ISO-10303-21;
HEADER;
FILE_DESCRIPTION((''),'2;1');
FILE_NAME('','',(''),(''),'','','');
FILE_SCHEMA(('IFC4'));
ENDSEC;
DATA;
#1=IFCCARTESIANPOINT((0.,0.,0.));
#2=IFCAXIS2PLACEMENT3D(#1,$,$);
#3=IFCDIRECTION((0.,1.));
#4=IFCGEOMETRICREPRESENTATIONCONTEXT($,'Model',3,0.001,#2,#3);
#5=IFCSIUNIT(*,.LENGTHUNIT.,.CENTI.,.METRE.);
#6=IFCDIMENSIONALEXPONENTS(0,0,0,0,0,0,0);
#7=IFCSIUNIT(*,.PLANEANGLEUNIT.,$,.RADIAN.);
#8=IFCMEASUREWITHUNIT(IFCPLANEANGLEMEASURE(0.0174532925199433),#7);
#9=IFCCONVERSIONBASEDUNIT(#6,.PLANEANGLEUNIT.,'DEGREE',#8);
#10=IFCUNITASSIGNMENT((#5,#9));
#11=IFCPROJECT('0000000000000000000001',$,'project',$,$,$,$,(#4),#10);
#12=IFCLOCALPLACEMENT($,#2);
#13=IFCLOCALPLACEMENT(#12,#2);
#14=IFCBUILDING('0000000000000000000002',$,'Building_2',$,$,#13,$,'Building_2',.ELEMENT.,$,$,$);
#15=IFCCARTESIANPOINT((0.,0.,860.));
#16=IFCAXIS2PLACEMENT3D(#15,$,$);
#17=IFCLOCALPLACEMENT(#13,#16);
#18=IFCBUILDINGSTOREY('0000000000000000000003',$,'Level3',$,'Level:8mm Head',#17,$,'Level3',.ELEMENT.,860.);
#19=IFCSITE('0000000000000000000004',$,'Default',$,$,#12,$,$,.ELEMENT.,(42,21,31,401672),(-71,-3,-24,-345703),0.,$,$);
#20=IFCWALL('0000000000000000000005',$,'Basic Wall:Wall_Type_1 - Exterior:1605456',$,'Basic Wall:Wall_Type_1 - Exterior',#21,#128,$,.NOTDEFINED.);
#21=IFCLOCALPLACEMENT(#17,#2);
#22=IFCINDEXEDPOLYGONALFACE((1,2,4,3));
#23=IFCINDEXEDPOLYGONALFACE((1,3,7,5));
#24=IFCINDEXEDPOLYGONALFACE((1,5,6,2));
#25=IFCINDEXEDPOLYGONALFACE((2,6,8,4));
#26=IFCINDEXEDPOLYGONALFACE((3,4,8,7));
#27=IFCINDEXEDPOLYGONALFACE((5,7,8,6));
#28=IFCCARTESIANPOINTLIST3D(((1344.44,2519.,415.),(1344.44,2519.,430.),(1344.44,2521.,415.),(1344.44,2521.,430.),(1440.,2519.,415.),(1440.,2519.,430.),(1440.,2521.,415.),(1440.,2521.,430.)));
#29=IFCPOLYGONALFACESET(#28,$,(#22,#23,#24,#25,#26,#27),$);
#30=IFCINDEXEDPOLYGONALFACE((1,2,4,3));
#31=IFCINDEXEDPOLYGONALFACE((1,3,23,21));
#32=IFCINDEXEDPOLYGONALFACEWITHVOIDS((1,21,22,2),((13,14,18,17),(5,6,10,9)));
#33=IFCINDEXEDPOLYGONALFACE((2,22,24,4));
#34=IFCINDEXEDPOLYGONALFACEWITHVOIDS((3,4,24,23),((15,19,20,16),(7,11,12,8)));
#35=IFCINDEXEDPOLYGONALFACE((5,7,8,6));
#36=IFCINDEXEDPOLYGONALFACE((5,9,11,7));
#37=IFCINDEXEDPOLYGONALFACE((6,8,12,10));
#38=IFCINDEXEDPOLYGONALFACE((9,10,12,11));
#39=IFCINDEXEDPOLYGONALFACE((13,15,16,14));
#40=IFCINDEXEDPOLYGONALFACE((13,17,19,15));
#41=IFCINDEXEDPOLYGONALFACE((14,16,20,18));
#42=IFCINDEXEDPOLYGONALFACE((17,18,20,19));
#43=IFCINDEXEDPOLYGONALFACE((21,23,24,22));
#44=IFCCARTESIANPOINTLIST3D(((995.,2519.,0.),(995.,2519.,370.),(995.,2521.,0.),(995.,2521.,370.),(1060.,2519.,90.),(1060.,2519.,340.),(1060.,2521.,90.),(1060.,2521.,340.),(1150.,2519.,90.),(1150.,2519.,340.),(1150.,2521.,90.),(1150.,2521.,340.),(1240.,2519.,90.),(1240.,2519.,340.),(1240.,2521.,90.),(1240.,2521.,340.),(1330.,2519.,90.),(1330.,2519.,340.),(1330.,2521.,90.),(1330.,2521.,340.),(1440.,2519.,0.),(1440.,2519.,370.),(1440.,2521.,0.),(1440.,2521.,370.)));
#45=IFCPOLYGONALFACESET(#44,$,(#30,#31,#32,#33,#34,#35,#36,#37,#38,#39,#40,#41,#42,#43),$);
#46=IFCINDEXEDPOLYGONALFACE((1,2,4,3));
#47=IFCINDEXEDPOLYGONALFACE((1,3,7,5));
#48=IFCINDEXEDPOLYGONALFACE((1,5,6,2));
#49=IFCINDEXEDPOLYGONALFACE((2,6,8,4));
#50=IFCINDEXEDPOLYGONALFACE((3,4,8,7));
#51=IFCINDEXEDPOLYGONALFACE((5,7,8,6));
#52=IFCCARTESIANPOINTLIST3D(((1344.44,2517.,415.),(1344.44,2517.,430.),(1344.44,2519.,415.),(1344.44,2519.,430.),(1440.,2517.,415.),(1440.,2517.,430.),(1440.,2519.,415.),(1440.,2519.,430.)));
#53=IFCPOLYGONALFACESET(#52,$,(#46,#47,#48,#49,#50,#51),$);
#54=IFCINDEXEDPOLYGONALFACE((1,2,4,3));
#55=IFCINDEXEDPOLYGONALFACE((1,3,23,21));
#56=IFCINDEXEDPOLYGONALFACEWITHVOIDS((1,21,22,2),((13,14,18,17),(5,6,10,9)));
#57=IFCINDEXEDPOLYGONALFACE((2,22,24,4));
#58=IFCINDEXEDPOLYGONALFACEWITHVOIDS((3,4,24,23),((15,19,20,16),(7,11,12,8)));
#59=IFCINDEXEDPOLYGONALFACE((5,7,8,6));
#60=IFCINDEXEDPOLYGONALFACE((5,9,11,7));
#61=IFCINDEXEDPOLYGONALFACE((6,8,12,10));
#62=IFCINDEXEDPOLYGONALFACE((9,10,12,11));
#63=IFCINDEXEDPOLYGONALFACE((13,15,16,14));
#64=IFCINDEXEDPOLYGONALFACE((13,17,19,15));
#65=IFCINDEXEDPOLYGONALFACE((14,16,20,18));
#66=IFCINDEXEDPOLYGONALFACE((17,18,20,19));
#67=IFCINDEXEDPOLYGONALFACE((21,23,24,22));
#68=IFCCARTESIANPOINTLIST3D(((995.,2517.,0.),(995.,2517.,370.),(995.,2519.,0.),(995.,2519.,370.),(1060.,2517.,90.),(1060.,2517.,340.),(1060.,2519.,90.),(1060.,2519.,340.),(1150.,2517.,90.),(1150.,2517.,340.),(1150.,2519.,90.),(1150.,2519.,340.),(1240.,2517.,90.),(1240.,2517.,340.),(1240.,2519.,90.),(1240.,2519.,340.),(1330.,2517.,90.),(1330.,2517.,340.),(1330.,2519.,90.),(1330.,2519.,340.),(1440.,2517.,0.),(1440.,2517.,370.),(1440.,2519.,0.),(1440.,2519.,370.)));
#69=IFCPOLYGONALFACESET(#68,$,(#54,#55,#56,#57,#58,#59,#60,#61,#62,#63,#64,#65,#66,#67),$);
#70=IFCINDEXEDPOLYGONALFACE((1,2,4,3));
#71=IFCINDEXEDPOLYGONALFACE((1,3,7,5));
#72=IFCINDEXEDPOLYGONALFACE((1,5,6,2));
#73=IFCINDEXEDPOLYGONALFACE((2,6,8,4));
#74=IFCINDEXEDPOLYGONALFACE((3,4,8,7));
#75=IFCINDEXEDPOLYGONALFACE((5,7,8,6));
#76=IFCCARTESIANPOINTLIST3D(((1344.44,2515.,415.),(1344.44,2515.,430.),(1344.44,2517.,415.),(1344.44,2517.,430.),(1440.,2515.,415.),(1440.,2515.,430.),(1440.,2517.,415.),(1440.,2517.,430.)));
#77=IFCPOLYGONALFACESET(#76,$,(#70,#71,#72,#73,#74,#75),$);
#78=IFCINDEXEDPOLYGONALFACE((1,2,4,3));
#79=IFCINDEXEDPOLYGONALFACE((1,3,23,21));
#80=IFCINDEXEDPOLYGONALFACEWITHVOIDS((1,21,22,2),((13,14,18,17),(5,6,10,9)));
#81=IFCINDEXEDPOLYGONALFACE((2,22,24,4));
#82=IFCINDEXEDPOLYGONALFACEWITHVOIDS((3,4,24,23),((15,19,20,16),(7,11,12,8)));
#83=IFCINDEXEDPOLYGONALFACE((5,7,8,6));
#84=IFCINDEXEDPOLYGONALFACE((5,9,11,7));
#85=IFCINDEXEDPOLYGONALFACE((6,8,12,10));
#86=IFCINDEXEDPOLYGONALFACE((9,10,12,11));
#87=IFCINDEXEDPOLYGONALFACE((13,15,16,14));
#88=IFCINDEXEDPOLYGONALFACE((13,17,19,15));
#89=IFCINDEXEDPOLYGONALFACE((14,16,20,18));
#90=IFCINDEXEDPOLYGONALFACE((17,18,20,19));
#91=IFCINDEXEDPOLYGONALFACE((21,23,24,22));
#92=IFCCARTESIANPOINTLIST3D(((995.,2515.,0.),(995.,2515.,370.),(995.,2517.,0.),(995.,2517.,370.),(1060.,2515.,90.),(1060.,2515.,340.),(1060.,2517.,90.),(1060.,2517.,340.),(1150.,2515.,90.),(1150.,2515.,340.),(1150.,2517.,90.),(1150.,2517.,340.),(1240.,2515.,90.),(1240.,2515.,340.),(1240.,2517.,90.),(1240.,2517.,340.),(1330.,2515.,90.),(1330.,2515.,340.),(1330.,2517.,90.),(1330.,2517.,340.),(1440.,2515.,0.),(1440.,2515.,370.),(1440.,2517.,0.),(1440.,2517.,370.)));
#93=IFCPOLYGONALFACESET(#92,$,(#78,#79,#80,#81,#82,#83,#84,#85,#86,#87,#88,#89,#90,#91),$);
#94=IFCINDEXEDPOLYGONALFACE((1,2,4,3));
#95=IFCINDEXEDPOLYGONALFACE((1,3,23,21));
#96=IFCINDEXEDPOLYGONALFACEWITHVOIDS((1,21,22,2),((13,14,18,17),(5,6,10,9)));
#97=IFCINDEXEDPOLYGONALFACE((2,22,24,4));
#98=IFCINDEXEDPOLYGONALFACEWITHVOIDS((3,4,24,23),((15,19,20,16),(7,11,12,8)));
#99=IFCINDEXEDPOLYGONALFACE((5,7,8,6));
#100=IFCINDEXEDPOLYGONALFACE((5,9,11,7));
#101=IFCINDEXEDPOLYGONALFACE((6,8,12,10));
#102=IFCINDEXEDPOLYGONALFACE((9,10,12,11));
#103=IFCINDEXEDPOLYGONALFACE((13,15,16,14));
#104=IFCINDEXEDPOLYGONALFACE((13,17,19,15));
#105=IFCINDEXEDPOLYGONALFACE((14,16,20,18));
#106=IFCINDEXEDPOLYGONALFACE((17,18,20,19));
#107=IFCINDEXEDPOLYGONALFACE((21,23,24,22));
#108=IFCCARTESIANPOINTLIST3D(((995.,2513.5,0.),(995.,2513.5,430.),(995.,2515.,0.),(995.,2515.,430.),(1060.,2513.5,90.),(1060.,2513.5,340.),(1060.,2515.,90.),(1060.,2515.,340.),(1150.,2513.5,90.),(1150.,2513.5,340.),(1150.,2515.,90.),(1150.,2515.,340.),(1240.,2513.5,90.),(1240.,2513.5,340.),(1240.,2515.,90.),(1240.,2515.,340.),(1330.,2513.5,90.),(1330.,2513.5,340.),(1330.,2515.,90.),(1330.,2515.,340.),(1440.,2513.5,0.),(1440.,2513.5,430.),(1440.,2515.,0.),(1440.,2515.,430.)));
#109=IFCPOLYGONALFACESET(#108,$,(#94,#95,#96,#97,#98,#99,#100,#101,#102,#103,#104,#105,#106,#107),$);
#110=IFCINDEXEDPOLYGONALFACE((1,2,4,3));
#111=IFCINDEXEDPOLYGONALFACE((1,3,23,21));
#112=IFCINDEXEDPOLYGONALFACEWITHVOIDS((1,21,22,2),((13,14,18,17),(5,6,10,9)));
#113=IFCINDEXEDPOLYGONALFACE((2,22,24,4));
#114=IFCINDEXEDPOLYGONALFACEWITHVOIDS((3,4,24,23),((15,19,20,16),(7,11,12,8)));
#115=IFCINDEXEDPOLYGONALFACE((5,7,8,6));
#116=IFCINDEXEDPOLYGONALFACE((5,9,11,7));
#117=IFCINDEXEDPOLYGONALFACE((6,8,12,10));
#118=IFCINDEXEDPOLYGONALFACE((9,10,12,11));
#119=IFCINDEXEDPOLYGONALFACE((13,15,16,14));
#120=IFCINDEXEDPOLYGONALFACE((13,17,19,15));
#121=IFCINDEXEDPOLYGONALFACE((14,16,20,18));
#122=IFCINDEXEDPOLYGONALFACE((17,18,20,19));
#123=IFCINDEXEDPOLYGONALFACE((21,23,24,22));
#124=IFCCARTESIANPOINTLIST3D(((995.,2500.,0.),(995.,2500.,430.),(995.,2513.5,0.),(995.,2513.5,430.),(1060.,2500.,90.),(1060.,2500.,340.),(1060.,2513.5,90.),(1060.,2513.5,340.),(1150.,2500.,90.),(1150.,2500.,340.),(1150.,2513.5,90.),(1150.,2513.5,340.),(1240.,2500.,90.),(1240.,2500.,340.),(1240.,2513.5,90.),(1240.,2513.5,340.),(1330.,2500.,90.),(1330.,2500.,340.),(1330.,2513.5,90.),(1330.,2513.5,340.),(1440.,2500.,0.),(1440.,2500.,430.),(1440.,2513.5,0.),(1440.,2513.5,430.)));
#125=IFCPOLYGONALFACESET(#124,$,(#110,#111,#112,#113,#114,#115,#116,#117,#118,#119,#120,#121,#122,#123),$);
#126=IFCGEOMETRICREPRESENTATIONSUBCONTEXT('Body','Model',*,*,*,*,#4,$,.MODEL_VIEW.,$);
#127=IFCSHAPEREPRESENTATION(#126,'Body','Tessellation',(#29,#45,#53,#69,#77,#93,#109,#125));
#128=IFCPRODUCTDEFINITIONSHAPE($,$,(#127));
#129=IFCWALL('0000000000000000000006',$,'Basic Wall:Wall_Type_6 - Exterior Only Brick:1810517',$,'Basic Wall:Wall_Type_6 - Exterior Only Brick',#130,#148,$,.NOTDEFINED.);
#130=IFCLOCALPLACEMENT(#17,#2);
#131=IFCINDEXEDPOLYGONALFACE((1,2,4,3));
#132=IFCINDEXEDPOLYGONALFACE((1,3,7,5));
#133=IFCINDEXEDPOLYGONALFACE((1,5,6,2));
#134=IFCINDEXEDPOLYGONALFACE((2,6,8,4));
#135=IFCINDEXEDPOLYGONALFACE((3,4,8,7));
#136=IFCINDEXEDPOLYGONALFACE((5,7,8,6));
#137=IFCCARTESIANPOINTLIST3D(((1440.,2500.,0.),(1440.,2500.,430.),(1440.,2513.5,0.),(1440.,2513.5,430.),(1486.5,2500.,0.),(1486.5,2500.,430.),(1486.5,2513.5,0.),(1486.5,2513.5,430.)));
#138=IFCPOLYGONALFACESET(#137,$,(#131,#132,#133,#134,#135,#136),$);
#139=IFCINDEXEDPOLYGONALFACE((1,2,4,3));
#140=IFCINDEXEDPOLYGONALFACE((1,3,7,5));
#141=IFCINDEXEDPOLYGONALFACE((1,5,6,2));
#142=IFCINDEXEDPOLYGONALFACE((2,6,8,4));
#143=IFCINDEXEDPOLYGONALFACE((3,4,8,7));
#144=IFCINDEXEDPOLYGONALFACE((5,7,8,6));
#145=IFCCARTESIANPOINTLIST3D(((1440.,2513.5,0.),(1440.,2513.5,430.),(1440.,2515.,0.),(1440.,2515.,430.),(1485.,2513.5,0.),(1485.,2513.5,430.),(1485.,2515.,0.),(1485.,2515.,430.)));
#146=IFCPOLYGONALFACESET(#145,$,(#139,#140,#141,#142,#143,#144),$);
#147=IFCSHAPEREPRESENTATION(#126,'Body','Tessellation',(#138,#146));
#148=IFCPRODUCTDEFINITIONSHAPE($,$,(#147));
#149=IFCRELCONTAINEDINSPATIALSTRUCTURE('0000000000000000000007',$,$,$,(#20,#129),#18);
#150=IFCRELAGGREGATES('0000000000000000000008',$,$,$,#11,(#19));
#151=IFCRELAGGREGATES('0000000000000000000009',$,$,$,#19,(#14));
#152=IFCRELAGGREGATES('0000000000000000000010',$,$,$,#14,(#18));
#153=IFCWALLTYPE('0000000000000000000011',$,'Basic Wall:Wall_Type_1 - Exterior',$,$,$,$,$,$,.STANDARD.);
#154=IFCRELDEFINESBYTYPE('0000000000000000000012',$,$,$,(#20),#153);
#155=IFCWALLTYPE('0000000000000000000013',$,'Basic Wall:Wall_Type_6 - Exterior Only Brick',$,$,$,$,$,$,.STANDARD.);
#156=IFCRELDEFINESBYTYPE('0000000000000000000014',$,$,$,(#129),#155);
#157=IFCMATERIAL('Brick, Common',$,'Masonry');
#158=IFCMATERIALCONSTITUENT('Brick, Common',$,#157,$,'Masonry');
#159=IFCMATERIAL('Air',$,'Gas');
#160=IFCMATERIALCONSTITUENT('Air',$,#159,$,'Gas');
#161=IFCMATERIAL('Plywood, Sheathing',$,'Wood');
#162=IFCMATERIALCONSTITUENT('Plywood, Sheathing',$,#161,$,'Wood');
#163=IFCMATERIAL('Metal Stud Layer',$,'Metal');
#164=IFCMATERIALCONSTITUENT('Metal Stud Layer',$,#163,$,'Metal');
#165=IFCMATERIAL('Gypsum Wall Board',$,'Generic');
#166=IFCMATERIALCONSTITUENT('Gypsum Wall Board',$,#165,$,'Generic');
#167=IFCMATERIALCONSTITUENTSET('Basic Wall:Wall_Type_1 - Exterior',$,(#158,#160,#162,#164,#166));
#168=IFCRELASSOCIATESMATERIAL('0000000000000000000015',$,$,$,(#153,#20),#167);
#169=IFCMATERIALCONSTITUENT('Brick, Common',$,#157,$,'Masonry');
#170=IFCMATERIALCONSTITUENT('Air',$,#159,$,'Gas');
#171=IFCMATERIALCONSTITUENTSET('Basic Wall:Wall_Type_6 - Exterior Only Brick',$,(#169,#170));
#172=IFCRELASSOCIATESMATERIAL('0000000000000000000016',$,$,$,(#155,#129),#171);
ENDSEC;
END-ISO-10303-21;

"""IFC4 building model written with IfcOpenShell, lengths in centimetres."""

from ifc_helpers import new_model, entity, si_unit, converted_unit, direction, frame, origin, place, context, subcontext, project, spatial, indexed_curve, outline, extrude, material, constituent, constituent_set, type_object, element, save


model = new_model("IFC4")

# Units and contexts
model_context = context("Model", 3, precision=0.001, world=origin(), true_north=direction((0.0, 1.0)))
body_context = subcontext(model_context, "Body", "Model", "MODEL_VIEW")
ifc_project = project(units=[si_unit("LENGTHUNIT", "METRE", prefix="CENTI"), converted_unit("PLANEANGLEUNIT", "DEGREE", entity("IfcPlaneAngleMeasure", 0.0174532925199433), si_unit("PLANEANGLEUNIT", "RADIAN"), dimensions=[0, 0, 0, 0, 0, 0, 0])], contexts=[model_context])

# Site, building, storey
site_placement = place(None, origin())
site = spatial("IfcSite", under=ifc_project, at=site_placement, Name="Default", CompositionType="ELEMENT", RefLatitude=(42, 21, 31, 401672), RefLongitude=(-71, -3, -24, -345703), RefElevation=0.0)
building_placement = place(site_placement, origin())
building = spatial("IfcBuilding", under=site, at=building_placement, Name="Building_2", LongName="Building_2", CompositionType="ELEMENT")
storey_placement = place(building_placement, frame((0.0, 0.0, 860.0)))
storey = spatial("IfcBuildingStorey", under=building, at=storey_placement, Name="Level3", ObjectType="Level:8mm Head", LongName="Level3", CompositionType="ELEMENT", Elevation=860.0)

# Wall, openings
ifc_material_1 = material(Name="Brick, Common", Category="Masonry")
ifc_constituent_1 = constituent(ifc_material_1, Name="Brick, Common", Category="Masonry")
ifc_material_2 = material(Name="Air", Category="Gas")
ifc_constituent_2 = constituent(ifc_material_2, Name="Air", Category="Gas")
ifc_material_3 = material(Name="Plywood, Sheathing", Category="Wood")
ifc_constituent_3 = constituent(ifc_material_3, Name="Plywood, Sheathing", Category="Wood")
ifc_material_4 = material(Name="Metal Stud Layer", Category="Metal")
ifc_constituent_4 = constituent(ifc_material_4, Name="Metal Stud Layer", Category="Metal")
ifc_material_5 = material(Name="Gypsum Wall Board", Category="Generic")
ifc_constituent_5 = constituent(ifc_material_5, Name="Gypsum Wall Board", Category="Generic")
ifc_constituent_set_1 = constituent_set(constituents=[ifc_constituent_1, ifc_constituent_2, ifc_constituent_3, ifc_constituent_4, ifc_constituent_5], Name="Basic Wall:Wall_Type_1 - Exterior")
wall_type_1 = type_object("IfcWallType", Name="Basic Wall:Wall_Type_1 - Exterior", PredefinedType="STANDARD", material=ifc_constituent_set_1)
wall_1_placement = place(storey_placement, frame((1440.0, 2510.5, 0.0), z_axis=(0.0, 0.0, 1.0), x_axis=(-1.0, 0.0, 0.0)))
wall_1 = element("IfcWall", 1, at=wall_1_placement, inside=storey, type_object=wall_type_1, material=ifc_constituent_set_1, Name="Basic Wall:Wall_Type_1 - Exterior:1605456", ObjectType="Basic Wall:Wall_Type_1 - Exterior", PredefinedType="NOTDEFINED", context=body_context, shape_type="SweptSolid", body=[
    extrude(outline(indexed_curve([(-7.5, -47.78), (7.5, -47.78), (7.5, 47.78), (-7.5, 47.78), (-7.5, -47.78)], self_intersect=False)), frame((47.78, -8.5, 422.5), z_axis=(0.0, -1.0, 0.0), x_axis=(0.0, 0.0, -1.0)), (0.0, 0.0, 1.0), 2.0),
    extrude(outline(indexed_curve([(-185.0, -222.5), (185.0, -222.5), (185.0, 222.5), (-185.0, 222.5), (-185.0, -222.5)], self_intersect=False), holes=[indexed_curve([(155.0, 112.5), (155.0, 22.5), (-95.0, 22.5), (-95.0, 112.5), (155.0, 112.5)], self_intersect=False), indexed_curve([(155.0, -67.5), (155.0, -157.5), (-95.0, -157.5), (-95.0, -67.5), (155.0, -67.5)], self_intersect=False)]), frame((222.5, -8.5, 185.0), z_axis=(0.0, -1.0, 0.0), x_axis=(0.0, 0.0, 1.0)), (0.0, 0.0, 1.0), 2.0),
    extrude(outline(indexed_curve([(-7.5, -47.78), (7.5, -47.78), (7.5, 47.78), (-7.5, 47.78), (-7.5, -47.78)], self_intersect=False)), frame((47.78, -6.5, 422.5), z_axis=(0.0, -1.0, 0.0), x_axis=(0.0, 0.0, -1.0)), (0.0, 0.0, 1.0), 2.0),
    extrude(outline(indexed_curve([(-185.0, -222.5), (185.0, -222.5), (185.0, 222.5), (-185.0, 222.5), (-185.0, -222.5)], self_intersect=False), holes=[indexed_curve([(155.0, 112.5), (155.0, 22.5), (-95.0, 22.5), (-95.0, 112.5), (155.0, 112.5)], self_intersect=False), indexed_curve([(155.0, -67.5), (155.0, -157.5), (-95.0, -157.5), (-95.0, -67.5), (155.0, -67.5)], self_intersect=False)]), frame((222.5, -6.5, 185.0), z_axis=(0.0, -1.0, 0.0), x_axis=(0.0, 0.0, 1.0)), (0.0, 0.0, 1.0), 2.0),
    extrude(outline(indexed_curve([(-7.5, -47.78), (7.5, -47.78), (7.5, 47.78), (-7.5, 47.78), (-7.5, -47.78)], self_intersect=False)), frame((47.78, -4.5, 422.5), z_axis=(0.0, -1.0, 0.0), x_axis=(0.0, 0.0, -1.0)), (0.0, 0.0, 1.0), 2.0),
    extrude(outline(indexed_curve([(-185.0, -222.5), (185.0, -222.5), (185.0, 222.5), (-185.0, 222.5), (-185.0, -222.5)], self_intersect=False), holes=[indexed_curve([(155.0, 112.5), (155.0, 22.5), (-95.0, 22.5), (-95.0, 112.5), (155.0, 112.5)], self_intersect=False), indexed_curve([(155.0, -67.5), (155.0, -157.5), (-95.0, -157.5), (-95.0, -67.5), (155.0, -67.5)], self_intersect=False)]), frame((222.5, -4.5, 185.0), z_axis=(0.0, -1.0, 0.0), x_axis=(0.0, 0.0, 1.0)), (0.0, 0.0, 1.0), 2.0),
    extrude(outline(indexed_curve([(-215.0, -222.5), (215.0, -222.5), (215.0, 222.5), (-215.0, 222.5), (-215.0, -222.5)], self_intersect=False), holes=[indexed_curve([(125.0, 112.5), (125.0, 22.5), (-125.0, 22.5), (-125.0, 112.5), (125.0, 112.5)], self_intersect=False), indexed_curve([(125.0, -67.5), (125.0, -157.5), (-125.0, -157.5), (-125.0, -67.5), (125.0, -67.5)], self_intersect=False)]), frame((222.5, -3.0, 215.0), z_axis=(0.0, -1.0, 0.0), x_axis=(0.0, 0.0, 1.0)), (0.0, 0.0, 1.0), 1.5),
    extrude(outline(indexed_curve([(-215.0, -222.5), (215.0, -222.5), (215.0, 222.5), (-215.0, 222.5), (-215.0, -222.5)], self_intersect=False), holes=[indexed_curve([(125.0, -67.5), (125.0, -157.5), (-125.0, -157.5), (-125.0, -67.5), (125.0, -67.5)], self_intersect=False), indexed_curve([(125.0, 112.5), (125.0, 22.5), (-125.0, 22.5), (-125.0, 112.5), (125.0, 112.5)], self_intersect=False)]), frame((222.5, 10.5, 215.0), z_axis=(0.0, -1.0, 0.0), x_axis=(0.0, 0.0, 1.0)), (0.0, 0.0, 1.0), 13.5),
])
opening_1_placement = place(wall_1_placement, frame((380.0, 10.5, 90.0)))
element("IfcOpeningElement", 2, at=opening_1_placement, cuts=wall_1, PredefinedType="OPENING", context=body_context, shape_type="SweptSolid", body=[
    extrude(outline(indexed_curve([(250.0, 90.0), (0.0, 90.0), (0.0, 0.0), (250.0, 0.0), (250.0, 90.0)], self_intersect=False)), frame((0.0, 0.0, 0.0), z_axis=(0.0, -1.0, 0.0), x_axis=(0.0, 0.0, 1.0)), (0.0, 0.0, 1.0), 21.0),
])
opening_2_placement = place(wall_1_placement, frame((200.0, 10.5, 90.0)))
element("IfcOpeningElement", 3, at=opening_2_placement, cuts=wall_1, PredefinedType="OPENING", context=body_context, shape_type="SweptSolid", body=[
    extrude(outline(indexed_curve([(250.0, 90.0), (0.0, 90.0), (0.0, 0.0), (250.0, 0.0), (250.0, 90.0)], self_intersect=False)), frame((0.0, 0.0, 0.0), z_axis=(0.0, -1.0, 0.0), x_axis=(0.0, 0.0, 1.0)), (0.0, 0.0, 1.0), 21.0),
])

# Wall
ifc_constituent_6 = constituent(ifc_material_1, Name="Brick, Common", Category="Masonry")
ifc_constituent_7 = constituent(ifc_material_2, Name="Air", Category="Gas")
ifc_constituent_set_2 = constituent_set(constituents=[ifc_constituent_6, ifc_constituent_7], Name="Basic Wall:Wall_Type_6 - Exterior Only Brick")
wall_type_2 = type_object("IfcWallType", Name="Basic Wall:Wall_Type_6 - Exterior Only Brick", PredefinedType="STANDARD", material=ifc_constituent_set_2)
wall_2_placement = place(storey_placement, frame((1485.0, 2507.5, 0.0), z_axis=(0.0, 0.0, 1.0), x_axis=(-1.0, 0.0, 0.0)))
element("IfcWall", 4, at=wall_2_placement, inside=storey, type_object=wall_type_2, material=ifc_constituent_set_2, Name="Basic Wall:Wall_Type_6 - Exterior Only Brick:1810517", ObjectType="Basic Wall:Wall_Type_6 - Exterior Only Brick", PredefinedType="NOTDEFINED", context=body_context, shape_type="SweptSolid", body=[
    extrude(outline(indexed_curve([(-6.75, -23.25), (6.75, -23.25), (6.75, 23.25), (-6.75, 23.25), (-6.75, -23.25)], self_intersect=False)), frame((21.75, 0.75, 0.0), z_axis=(0.0, 0.0, 1.0), x_axis=(0.0, -1.0, 0.0)), (0.0, 0.0, 1.0), 430.0),
    extrude(outline(indexed_curve([(-0.75, -22.5), (0.75, -22.5), (0.75, 22.5), (-0.75, 22.5), (-0.75, -22.5)], self_intersect=False)), frame((22.5, -6.75, 0.0), z_axis=(0.0, 0.0, 1.0), x_axis=(0.0, 1.0, 0.0)), (0.0, 0.0, 1.0), 430.0),
])

save(model, "model.ifc")
